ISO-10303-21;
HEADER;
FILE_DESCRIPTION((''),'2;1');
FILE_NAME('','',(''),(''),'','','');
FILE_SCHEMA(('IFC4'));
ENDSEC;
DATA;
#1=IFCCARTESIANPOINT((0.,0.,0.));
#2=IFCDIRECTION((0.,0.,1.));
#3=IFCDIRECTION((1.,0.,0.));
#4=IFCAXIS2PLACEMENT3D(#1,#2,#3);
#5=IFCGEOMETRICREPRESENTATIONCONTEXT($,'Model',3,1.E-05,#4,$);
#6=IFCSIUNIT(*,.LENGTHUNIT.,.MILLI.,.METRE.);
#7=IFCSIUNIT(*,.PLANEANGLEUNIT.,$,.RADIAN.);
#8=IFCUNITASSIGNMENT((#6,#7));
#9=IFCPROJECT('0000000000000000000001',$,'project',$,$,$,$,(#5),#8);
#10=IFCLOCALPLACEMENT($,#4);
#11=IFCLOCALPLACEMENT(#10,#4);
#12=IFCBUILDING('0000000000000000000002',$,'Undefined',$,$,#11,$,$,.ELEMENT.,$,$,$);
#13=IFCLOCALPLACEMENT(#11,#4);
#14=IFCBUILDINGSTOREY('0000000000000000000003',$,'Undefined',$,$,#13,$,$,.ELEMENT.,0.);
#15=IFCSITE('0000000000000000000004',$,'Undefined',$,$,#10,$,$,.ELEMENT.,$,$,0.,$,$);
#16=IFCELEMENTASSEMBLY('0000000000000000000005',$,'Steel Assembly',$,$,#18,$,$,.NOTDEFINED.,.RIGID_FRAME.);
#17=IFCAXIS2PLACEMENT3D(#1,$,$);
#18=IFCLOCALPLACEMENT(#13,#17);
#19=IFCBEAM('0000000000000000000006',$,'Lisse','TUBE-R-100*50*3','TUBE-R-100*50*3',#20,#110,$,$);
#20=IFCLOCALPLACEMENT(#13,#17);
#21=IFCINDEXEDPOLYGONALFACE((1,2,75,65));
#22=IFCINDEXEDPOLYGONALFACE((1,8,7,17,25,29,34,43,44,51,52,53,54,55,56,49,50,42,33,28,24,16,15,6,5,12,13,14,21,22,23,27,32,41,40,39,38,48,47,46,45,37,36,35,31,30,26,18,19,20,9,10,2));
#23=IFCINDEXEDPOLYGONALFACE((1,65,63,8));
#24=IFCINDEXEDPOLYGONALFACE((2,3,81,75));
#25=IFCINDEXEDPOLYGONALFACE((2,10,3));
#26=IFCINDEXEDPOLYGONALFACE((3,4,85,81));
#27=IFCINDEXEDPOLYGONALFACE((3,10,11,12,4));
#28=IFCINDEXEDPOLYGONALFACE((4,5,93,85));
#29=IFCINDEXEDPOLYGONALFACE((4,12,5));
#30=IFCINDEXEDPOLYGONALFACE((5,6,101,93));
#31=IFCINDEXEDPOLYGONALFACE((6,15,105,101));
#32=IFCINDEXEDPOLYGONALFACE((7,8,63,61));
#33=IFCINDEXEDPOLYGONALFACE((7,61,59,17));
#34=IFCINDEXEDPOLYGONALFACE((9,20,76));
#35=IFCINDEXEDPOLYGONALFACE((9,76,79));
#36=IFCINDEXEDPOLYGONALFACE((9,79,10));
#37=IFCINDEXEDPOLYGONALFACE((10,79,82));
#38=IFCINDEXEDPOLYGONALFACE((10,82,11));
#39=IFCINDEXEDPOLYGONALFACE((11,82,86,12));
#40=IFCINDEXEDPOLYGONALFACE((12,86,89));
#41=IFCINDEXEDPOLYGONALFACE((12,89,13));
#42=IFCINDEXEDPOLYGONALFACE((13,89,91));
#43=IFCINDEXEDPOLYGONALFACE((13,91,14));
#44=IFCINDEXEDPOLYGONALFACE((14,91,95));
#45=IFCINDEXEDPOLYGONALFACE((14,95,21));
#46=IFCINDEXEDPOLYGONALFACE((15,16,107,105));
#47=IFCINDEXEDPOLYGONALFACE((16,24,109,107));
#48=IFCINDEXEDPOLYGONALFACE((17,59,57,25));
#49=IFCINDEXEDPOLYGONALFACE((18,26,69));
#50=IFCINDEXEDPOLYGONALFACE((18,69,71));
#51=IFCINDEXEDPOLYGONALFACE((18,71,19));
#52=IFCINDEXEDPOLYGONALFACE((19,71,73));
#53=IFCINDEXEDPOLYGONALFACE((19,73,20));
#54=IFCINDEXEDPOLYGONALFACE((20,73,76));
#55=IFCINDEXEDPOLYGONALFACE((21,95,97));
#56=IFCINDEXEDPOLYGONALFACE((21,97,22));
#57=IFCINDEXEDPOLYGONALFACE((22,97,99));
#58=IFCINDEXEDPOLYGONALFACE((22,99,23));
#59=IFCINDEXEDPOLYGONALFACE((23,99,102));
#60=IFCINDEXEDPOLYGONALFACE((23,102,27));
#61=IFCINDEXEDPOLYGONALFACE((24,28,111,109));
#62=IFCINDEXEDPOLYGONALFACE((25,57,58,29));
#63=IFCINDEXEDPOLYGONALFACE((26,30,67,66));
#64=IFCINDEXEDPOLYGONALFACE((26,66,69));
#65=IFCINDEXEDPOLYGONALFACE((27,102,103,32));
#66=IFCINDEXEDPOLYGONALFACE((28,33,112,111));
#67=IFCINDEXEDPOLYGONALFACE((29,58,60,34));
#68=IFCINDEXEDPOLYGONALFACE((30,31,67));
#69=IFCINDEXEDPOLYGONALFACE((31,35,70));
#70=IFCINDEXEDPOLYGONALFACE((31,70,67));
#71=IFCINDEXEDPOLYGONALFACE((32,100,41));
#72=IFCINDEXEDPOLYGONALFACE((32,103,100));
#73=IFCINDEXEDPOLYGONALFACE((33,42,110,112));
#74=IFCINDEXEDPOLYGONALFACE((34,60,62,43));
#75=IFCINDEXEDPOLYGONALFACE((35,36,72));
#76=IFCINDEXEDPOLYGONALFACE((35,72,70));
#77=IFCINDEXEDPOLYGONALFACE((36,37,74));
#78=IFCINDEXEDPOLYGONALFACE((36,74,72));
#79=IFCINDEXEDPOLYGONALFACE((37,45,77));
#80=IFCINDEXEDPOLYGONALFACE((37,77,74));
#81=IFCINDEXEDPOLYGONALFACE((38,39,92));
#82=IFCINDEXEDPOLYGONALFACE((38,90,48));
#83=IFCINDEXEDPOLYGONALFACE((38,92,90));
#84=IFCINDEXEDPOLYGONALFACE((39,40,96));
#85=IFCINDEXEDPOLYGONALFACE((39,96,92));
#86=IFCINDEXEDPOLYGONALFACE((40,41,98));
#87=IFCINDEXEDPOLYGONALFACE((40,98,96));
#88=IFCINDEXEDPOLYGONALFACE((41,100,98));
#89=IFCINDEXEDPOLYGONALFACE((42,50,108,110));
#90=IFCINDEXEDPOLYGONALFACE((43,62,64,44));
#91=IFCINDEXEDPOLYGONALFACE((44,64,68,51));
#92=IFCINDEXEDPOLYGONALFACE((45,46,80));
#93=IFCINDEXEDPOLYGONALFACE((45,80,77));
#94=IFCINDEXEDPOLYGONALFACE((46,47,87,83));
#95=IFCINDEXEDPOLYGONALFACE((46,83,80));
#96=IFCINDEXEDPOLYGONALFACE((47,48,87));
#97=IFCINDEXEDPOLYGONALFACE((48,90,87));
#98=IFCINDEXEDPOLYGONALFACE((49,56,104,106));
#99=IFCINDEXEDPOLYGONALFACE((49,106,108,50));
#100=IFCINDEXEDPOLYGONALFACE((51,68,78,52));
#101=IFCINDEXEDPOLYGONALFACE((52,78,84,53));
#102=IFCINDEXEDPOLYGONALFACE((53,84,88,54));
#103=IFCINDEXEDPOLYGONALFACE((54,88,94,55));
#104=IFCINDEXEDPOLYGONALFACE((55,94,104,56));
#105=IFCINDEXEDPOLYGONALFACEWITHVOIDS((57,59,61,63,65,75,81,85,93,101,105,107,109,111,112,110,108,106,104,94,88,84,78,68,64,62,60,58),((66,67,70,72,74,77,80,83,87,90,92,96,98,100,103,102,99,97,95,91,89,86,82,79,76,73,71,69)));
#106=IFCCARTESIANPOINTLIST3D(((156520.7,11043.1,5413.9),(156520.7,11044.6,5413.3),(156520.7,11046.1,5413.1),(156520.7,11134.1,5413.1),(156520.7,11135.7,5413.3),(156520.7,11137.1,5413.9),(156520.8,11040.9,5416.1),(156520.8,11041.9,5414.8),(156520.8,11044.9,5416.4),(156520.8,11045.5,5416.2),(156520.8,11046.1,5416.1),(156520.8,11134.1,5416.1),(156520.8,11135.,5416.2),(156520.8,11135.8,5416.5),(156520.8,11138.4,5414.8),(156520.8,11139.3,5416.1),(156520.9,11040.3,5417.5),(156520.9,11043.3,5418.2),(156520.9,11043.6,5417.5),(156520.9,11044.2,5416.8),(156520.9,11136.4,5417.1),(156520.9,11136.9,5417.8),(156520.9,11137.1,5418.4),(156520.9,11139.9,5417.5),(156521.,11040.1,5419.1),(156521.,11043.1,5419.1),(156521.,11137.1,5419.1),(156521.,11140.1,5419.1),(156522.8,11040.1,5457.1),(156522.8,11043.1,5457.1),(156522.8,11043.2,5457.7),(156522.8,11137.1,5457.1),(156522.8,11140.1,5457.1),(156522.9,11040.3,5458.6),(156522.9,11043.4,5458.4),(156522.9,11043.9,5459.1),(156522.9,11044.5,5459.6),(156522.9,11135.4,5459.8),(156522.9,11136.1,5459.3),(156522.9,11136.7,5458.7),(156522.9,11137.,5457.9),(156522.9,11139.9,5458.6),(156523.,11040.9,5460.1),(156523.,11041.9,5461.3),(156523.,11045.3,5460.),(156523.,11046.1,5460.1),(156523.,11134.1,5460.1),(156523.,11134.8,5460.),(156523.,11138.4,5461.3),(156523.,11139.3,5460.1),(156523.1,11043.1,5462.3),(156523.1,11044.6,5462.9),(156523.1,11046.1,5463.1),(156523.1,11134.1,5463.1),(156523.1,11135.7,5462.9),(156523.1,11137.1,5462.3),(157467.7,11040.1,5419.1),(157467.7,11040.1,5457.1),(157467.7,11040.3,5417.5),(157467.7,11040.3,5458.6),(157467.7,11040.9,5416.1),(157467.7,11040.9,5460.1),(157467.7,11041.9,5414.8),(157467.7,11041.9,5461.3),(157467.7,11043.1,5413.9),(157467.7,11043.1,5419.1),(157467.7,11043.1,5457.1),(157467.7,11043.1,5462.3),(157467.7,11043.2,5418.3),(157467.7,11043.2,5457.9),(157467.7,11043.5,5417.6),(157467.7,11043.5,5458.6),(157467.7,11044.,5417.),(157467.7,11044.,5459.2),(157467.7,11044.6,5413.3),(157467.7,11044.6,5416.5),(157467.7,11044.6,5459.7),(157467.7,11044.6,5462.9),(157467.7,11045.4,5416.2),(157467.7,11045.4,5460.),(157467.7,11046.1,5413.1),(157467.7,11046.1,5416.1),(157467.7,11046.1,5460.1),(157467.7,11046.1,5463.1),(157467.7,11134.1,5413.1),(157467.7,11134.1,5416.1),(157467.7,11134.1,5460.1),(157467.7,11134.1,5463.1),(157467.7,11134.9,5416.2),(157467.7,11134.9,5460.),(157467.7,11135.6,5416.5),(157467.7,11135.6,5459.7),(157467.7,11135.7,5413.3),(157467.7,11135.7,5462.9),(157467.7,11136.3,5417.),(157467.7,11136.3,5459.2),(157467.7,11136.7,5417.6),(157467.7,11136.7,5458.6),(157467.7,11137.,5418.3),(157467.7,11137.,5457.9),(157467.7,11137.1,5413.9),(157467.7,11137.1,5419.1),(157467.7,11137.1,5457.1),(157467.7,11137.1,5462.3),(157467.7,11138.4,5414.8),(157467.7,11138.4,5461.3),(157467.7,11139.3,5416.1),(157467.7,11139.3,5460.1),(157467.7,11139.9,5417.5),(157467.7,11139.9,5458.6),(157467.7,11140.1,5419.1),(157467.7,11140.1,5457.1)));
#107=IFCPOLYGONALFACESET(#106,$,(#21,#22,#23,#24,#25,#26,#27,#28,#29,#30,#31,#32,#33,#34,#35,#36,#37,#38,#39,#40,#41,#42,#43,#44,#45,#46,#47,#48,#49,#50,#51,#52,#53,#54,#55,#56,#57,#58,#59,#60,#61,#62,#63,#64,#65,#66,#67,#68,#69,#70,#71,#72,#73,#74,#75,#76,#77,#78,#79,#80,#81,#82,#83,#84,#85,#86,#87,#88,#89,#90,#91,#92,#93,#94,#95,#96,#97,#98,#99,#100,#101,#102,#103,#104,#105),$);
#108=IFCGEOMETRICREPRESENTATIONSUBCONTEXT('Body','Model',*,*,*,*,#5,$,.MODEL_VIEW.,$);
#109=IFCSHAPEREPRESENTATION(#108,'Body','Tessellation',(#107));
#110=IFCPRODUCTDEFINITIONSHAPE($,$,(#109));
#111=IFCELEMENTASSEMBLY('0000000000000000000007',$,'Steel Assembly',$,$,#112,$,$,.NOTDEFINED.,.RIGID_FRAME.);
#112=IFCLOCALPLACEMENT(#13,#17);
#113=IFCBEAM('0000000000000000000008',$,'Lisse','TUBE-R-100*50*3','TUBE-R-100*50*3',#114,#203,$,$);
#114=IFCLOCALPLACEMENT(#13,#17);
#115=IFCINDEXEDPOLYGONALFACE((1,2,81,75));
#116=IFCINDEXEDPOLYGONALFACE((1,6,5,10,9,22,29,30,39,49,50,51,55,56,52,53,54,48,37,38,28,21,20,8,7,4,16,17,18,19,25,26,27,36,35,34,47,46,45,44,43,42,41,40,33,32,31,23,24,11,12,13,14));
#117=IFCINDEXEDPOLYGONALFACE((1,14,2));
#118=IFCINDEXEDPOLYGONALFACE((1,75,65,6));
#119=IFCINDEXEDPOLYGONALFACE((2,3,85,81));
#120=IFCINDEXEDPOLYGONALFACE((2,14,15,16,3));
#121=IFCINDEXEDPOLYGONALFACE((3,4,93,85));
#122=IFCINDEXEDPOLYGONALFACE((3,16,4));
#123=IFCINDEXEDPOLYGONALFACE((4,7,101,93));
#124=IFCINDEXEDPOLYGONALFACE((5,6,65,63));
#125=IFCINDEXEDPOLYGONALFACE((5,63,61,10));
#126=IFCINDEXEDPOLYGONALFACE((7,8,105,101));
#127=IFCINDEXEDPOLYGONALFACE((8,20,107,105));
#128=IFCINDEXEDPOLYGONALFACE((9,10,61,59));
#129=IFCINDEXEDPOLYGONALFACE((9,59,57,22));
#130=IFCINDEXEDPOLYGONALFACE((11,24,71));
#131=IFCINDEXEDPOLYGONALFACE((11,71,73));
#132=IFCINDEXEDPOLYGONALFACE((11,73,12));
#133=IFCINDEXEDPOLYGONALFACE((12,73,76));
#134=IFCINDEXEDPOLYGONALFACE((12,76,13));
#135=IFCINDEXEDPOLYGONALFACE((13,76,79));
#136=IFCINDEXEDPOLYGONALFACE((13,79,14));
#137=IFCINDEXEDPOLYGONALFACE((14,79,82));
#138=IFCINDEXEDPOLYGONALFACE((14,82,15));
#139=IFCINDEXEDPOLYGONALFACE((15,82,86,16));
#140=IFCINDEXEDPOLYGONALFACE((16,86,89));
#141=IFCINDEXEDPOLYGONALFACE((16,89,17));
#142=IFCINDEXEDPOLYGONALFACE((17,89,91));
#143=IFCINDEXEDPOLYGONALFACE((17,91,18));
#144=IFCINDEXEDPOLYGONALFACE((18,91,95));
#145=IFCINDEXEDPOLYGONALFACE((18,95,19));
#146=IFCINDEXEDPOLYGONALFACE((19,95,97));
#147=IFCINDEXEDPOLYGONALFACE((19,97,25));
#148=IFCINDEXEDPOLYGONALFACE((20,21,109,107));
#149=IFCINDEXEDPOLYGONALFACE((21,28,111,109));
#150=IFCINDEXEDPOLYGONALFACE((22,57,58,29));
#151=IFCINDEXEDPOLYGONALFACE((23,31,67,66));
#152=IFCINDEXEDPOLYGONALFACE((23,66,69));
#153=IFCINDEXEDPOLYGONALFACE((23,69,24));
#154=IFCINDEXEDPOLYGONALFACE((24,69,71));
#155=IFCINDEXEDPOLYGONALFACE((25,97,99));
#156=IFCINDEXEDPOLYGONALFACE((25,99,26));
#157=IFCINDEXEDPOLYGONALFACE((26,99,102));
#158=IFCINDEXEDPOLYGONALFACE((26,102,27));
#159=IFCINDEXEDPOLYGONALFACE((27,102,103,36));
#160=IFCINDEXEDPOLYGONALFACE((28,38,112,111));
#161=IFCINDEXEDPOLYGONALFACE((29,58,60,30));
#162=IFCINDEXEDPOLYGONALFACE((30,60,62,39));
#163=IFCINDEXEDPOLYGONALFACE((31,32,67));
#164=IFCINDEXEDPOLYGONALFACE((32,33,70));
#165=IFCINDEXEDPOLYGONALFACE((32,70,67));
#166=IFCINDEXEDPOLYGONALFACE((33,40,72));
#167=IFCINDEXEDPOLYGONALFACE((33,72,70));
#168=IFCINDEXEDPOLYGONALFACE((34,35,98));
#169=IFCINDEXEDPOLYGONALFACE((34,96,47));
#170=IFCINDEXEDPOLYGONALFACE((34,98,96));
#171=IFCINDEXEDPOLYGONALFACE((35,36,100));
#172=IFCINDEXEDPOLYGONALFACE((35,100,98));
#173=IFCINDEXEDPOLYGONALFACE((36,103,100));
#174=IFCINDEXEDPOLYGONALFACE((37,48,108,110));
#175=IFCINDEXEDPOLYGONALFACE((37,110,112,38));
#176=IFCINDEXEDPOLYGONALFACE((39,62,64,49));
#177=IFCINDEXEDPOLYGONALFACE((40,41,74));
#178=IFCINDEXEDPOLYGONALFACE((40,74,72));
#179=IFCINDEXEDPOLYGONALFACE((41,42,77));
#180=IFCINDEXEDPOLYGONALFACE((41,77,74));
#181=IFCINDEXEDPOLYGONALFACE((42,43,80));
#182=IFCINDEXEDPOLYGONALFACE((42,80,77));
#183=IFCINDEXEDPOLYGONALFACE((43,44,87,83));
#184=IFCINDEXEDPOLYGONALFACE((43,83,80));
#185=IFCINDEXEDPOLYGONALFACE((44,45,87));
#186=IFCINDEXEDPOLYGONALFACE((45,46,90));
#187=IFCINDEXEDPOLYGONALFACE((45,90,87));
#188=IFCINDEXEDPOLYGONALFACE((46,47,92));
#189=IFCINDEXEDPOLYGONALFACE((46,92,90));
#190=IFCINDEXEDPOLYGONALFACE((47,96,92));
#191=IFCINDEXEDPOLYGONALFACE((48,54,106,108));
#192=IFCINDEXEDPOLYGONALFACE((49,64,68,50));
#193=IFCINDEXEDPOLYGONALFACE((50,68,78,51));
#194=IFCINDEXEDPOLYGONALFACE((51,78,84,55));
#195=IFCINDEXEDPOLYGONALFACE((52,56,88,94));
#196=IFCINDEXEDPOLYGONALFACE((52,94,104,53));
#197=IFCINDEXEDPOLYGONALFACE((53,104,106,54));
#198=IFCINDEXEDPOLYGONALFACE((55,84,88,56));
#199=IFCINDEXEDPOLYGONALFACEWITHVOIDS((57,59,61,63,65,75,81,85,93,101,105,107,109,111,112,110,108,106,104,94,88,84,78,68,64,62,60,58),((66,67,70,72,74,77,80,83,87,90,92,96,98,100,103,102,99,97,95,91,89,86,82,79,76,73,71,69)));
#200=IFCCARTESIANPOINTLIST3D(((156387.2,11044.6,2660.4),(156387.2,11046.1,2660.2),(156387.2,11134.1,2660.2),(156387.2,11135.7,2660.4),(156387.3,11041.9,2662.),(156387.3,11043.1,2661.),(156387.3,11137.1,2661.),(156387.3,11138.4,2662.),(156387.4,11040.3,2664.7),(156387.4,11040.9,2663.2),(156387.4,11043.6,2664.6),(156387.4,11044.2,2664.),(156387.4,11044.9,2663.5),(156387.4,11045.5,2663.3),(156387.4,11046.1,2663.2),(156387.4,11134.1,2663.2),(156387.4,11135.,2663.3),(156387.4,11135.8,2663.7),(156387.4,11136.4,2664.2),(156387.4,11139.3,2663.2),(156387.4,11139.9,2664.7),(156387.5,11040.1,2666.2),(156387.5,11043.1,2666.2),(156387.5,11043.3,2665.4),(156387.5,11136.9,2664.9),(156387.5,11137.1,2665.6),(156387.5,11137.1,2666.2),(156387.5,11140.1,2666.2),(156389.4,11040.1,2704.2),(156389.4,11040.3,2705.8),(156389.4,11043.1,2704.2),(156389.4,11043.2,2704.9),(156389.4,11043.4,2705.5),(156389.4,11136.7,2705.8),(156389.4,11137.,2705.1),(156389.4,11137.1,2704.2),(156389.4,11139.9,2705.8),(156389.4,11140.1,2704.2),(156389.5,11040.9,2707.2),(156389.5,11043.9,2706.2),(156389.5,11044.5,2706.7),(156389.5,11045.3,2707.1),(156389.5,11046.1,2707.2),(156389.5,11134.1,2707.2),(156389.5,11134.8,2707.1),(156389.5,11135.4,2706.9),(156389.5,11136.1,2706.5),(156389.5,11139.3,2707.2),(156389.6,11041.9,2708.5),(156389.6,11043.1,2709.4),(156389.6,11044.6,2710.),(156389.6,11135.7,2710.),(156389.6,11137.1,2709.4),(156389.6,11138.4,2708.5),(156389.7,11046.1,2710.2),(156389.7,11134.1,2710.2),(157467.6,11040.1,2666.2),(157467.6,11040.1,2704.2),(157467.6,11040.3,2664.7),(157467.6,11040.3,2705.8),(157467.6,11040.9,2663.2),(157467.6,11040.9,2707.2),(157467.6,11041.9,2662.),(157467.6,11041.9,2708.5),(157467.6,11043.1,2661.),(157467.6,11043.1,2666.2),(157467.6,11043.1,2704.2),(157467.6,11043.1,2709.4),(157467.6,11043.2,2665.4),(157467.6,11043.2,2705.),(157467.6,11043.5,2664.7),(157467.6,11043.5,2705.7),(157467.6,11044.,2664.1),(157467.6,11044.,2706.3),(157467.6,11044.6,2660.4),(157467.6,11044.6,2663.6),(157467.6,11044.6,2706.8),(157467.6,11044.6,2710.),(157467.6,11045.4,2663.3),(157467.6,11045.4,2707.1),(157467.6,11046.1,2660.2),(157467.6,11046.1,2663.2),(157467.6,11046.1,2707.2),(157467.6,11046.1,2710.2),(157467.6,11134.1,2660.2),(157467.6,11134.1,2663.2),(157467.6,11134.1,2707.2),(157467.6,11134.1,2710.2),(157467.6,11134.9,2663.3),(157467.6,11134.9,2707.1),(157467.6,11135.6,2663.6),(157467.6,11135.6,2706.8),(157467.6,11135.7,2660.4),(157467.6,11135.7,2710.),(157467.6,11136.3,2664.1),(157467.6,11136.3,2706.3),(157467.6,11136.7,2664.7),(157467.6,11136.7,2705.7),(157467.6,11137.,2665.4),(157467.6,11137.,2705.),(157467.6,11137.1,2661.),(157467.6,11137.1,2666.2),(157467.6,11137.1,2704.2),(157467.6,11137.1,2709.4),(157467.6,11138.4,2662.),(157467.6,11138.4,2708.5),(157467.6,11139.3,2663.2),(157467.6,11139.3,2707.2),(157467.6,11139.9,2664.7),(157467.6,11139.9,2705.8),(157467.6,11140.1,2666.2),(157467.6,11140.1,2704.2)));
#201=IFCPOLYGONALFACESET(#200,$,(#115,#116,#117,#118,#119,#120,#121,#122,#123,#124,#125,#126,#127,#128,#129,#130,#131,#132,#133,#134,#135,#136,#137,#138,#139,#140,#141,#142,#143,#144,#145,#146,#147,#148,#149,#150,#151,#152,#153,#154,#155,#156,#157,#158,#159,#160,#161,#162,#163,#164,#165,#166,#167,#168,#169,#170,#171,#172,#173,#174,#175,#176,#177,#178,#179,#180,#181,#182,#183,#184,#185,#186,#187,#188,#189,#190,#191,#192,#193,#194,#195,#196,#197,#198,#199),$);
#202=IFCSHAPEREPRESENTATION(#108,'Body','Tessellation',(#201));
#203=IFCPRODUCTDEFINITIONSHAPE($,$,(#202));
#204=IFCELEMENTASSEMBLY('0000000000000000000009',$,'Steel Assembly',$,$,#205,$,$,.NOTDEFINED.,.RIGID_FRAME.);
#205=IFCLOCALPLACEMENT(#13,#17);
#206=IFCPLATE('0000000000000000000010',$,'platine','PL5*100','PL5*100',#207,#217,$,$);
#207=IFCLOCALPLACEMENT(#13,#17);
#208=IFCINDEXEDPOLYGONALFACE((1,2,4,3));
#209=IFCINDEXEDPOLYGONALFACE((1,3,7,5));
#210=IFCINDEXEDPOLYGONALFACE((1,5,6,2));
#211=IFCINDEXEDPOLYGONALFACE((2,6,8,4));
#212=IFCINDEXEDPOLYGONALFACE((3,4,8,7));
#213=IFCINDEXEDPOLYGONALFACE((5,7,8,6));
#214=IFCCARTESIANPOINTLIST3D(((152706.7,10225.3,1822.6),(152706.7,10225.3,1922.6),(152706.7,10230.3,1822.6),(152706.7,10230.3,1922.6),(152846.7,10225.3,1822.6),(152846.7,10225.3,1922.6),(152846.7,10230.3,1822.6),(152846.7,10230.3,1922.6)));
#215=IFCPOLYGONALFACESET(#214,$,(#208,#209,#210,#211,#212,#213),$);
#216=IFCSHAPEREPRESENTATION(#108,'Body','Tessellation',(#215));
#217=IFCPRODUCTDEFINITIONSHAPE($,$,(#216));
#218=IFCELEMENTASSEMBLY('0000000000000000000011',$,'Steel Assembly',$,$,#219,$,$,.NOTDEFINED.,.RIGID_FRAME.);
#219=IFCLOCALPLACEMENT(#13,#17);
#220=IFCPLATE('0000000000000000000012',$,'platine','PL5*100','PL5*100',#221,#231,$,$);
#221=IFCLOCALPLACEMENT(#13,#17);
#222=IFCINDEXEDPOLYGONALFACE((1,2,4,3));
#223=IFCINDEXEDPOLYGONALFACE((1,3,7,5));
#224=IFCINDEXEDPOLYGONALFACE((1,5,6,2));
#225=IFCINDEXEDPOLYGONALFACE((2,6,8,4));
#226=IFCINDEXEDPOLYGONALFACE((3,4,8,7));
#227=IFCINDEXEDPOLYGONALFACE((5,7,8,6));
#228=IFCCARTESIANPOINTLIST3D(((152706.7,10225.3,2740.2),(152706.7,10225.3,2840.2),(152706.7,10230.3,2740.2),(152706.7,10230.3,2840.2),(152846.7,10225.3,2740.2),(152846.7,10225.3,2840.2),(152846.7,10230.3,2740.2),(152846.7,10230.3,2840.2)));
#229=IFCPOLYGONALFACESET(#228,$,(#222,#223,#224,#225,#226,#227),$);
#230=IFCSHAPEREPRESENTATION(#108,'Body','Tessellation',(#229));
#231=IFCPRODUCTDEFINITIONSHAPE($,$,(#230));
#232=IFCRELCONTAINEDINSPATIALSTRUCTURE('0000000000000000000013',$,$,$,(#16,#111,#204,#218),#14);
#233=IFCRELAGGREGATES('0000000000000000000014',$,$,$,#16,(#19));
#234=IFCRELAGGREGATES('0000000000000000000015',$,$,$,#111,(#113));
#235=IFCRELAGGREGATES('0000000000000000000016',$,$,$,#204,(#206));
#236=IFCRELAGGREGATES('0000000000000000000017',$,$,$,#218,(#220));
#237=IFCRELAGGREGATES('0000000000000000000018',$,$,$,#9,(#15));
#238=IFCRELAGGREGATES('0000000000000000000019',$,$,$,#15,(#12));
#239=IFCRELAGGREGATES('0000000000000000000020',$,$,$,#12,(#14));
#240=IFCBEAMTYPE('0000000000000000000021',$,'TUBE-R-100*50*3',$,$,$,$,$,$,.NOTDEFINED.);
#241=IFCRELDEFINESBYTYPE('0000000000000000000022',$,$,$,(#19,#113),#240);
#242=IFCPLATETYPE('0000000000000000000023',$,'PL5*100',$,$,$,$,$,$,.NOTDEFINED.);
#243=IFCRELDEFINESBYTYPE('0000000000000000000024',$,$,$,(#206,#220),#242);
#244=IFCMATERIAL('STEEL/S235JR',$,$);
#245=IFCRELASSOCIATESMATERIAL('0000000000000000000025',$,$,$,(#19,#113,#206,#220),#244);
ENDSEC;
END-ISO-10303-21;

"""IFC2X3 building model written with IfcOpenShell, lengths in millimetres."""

from ifc_helpers import new_model, si_unit, frame, origin_with_axes, origin_2d_with_axis, place, context, subcontext, project, spatial, polyline, hollow_rectangle, outline, extrude, clip, halfspace, material, type_object, element, aggregate, save


model = new_model("IFC2X3")

# Units and contexts
model_context = context("Model", 3, precision=1e-05, world=origin_with_axes())
body_context = subcontext(model_context, "Body", "Model", "MODEL_VIEW")
ifc_project = project(units=[si_unit("LENGTHUNIT", "METRE", prefix="MILLI"), si_unit("PLANEANGLEUNIT", "RADIAN")], contexts=[model_context])

# Site, building, storey
site_placement = place(None, origin_with_axes())
site = spatial("IfcSite", under=ifc_project, at=site_placement, Name="Undefined", CompositionType="ELEMENT", RefElevation=0.0)
building_placement = place(site_placement, origin_with_axes())
building = spatial("IfcBuilding", under=site, at=building_placement, Name="Undefined", CompositionType="ELEMENT")
storey_placement = place(building_placement, origin_with_axes())
storey = spatial("IfcBuildingStorey", under=building, at=storey_placement, Name="Undefined", CompositionType="ELEMENT", Elevation=0.0)

# Element assemblies, beams
ifc_material_1 = material(Name="STEEL/S235JR")
beam_type_1 = type_object("IfcBeamType", Name="TUBE-R-100*50*3", PredefinedType="NOTDEFINED")
assembly_1_placement = place(storey_placement, origin_with_axes())
assembly_1 = element("IfcElementAssembly", 1, at=assembly_1_placement, inside=storey, Name="Steel Assembly", AssemblyPlace="NOTDEFINED", PredefinedType="RIGID_FRAME")
beam_1_placement = place(assembly_1_placement, frame((157467.6, 11090.1, 5438.1), z_axis=(0.0, 1.0, 0.0), x_axis=(-1.0, 0.0, 0.0)))
beam_1 = element("IfcBeam", 2, at=beam_1_placement, type_object=beam_type_1, material=ifc_material_1, Name="Lisse", Description="TUBE-R-100*50*3", ObjectType="TUBE-R-100*50*3", context=body_context, shape_type="Clipping", body=[
    clip(clip(extrude(hollow_rectangle(XDim=50.0, YDim=100.0, WallThickness=3.0, InnerFilletRadius=3.0, OuterFilletRadius=6.0, at=origin_2d_with_axis()), frame((947.0, 0.0, 0.0), z_axis=(-1.0, 0.0, 0.0), x_axis=(0.0, -1.0, 0.0)), (0.0, 0.0, 1.0), 947.0), halfspace(frame((0.0, 25.0, -75.0), z_axis=(-1.0, 0.000001, 0.0), x_axis=(0.0, 0.0, 1.0)), False)), halfspace(frame((948.3, -52.1, -959.8), z_axis=(-0.998827, -0.04842, 0.0), x_axis=(0.0, 0.0, -1.0)), True)),
])
aggregate(assembly_1, [beam_1])
assembly_2_placement = place(storey_placement, origin_with_axes())
assembly_2 = element("IfcElementAssembly", 3, at=assembly_2_placement, inside=storey, Name="Steel Assembly", AssemblyPlace="NOTDEFINED", PredefinedType="RIGID_FRAME")
beam_2_placement = place(assembly_2_placement, frame((157467.6, 11090.1, 2685.2), z_axis=(0.0, 1.0, 0.0), x_axis=(-1.0, 0.0, 0.0)))
beam_2 = element("IfcBeam", 4, at=beam_2_placement, type_object=beam_type_1, material=ifc_material_1, Name="Lisse", Description="TUBE-R-100*50*3", ObjectType="TUBE-R-100*50*3", context=body_context, shape_type="Clipping", body=[
    clip(clip(extrude(hollow_rectangle(XDim=50.0, YDim=100.0, WallThickness=3.0, InnerFilletRadius=3.0, OuterFilletRadius=6.0, at=origin_2d_with_axis()), frame((1080.4, 0.0, 0.0), z_axis=(-1.0, 0.0, 0.0), x_axis=(0.0, -1.0, 0.0)), (0.0, 0.0, 1.0), 1080.4), halfspace(frame((0.0, 25.0, -75.0), z_axis=(-1.0, 0.000001, 0.0), x_axis=(0.0, 0.0, 1.0)), False)), halfspace(frame((1081.6, -49.3, -959.8), z_axis=(-0.998827, -0.04842, 0.0), x_axis=(0.0, 0.0, -1.0)), True)),
])
aggregate(assembly_2, [beam_2])

# Element assemblies, plates
assembly_3_placement = place(storey_placement, origin_with_axes())
assembly_3 = element("IfcElementAssembly", 5, at=assembly_3_placement, inside=storey, Name="Steel Assembly", AssemblyPlace="NOTDEFINED", PredefinedType="RIGID_FRAME")
plate_type_1 = type_object("IfcPlateType", Name="PL5*100", PredefinedType="NOTDEFINED")
plate_1_placement = place(assembly_3_placement, frame((152846.7, 10227.8, 1922.6), z_axis=(0.0, -1.0, 0.0), x_axis=(-1.0, 0.0, 0.0)))
plate_1 = element("IfcPlate", 6, at=plate_1_placement, type_object=plate_type_1, material=ifc_material_1, Name="platine", Description="PL5*100", ObjectType="PL5*100", context=body_context, shape_type="SweptSolid", body=[
    extrude(outline(polyline([(0.0, 0.0), (140.0, 0.0), (140.0, 100.0), (0.0, 100.0), (0.0, 0.0)])), frame((0.0, 0.0, -2.5), z_axis=(0.0, 0.0, 1.0), x_axis=(1.0, 0.0, 0.0)), (0.0, 0.0, 1.0), 5.0),
])
aggregate(assembly_3, [plate_1])
assembly_4_placement = place(storey_placement, origin_with_axes())
assembly_4 = element("IfcElementAssembly", 7, at=assembly_4_placement, inside=storey, Name="Steel Assembly", AssemblyPlace="NOTDEFINED", PredefinedType="RIGID_FRAME")
plate_2_placement = place(assembly_4_placement, frame((152846.7, 10227.8, 2840.2), z_axis=(0.0, -1.0, 0.0), x_axis=(-1.0, 0.0, 0.0)))
plate_2 = element("IfcPlate", 8, at=plate_2_placement, type_object=plate_type_1, material=ifc_material_1, Name="platine", Description="PL5*100", ObjectType="PL5*100", context=body_context, shape_type="SweptSolid", body=[
    extrude(outline(polyline([(0.0, 0.0), (140.0, 0.0), (140.0, 100.0), (0.0, 100.0), (0.0, 0.0)])), frame((0.0, 0.0, -2.5), z_axis=(0.0, 0.0, 1.0), x_axis=(1.0, 0.0, 0.0)), (0.0, 0.0, 1.0), 5.0),
])

aggregate(assembly_4, [plate_2])

save(model, "model.ifc")
